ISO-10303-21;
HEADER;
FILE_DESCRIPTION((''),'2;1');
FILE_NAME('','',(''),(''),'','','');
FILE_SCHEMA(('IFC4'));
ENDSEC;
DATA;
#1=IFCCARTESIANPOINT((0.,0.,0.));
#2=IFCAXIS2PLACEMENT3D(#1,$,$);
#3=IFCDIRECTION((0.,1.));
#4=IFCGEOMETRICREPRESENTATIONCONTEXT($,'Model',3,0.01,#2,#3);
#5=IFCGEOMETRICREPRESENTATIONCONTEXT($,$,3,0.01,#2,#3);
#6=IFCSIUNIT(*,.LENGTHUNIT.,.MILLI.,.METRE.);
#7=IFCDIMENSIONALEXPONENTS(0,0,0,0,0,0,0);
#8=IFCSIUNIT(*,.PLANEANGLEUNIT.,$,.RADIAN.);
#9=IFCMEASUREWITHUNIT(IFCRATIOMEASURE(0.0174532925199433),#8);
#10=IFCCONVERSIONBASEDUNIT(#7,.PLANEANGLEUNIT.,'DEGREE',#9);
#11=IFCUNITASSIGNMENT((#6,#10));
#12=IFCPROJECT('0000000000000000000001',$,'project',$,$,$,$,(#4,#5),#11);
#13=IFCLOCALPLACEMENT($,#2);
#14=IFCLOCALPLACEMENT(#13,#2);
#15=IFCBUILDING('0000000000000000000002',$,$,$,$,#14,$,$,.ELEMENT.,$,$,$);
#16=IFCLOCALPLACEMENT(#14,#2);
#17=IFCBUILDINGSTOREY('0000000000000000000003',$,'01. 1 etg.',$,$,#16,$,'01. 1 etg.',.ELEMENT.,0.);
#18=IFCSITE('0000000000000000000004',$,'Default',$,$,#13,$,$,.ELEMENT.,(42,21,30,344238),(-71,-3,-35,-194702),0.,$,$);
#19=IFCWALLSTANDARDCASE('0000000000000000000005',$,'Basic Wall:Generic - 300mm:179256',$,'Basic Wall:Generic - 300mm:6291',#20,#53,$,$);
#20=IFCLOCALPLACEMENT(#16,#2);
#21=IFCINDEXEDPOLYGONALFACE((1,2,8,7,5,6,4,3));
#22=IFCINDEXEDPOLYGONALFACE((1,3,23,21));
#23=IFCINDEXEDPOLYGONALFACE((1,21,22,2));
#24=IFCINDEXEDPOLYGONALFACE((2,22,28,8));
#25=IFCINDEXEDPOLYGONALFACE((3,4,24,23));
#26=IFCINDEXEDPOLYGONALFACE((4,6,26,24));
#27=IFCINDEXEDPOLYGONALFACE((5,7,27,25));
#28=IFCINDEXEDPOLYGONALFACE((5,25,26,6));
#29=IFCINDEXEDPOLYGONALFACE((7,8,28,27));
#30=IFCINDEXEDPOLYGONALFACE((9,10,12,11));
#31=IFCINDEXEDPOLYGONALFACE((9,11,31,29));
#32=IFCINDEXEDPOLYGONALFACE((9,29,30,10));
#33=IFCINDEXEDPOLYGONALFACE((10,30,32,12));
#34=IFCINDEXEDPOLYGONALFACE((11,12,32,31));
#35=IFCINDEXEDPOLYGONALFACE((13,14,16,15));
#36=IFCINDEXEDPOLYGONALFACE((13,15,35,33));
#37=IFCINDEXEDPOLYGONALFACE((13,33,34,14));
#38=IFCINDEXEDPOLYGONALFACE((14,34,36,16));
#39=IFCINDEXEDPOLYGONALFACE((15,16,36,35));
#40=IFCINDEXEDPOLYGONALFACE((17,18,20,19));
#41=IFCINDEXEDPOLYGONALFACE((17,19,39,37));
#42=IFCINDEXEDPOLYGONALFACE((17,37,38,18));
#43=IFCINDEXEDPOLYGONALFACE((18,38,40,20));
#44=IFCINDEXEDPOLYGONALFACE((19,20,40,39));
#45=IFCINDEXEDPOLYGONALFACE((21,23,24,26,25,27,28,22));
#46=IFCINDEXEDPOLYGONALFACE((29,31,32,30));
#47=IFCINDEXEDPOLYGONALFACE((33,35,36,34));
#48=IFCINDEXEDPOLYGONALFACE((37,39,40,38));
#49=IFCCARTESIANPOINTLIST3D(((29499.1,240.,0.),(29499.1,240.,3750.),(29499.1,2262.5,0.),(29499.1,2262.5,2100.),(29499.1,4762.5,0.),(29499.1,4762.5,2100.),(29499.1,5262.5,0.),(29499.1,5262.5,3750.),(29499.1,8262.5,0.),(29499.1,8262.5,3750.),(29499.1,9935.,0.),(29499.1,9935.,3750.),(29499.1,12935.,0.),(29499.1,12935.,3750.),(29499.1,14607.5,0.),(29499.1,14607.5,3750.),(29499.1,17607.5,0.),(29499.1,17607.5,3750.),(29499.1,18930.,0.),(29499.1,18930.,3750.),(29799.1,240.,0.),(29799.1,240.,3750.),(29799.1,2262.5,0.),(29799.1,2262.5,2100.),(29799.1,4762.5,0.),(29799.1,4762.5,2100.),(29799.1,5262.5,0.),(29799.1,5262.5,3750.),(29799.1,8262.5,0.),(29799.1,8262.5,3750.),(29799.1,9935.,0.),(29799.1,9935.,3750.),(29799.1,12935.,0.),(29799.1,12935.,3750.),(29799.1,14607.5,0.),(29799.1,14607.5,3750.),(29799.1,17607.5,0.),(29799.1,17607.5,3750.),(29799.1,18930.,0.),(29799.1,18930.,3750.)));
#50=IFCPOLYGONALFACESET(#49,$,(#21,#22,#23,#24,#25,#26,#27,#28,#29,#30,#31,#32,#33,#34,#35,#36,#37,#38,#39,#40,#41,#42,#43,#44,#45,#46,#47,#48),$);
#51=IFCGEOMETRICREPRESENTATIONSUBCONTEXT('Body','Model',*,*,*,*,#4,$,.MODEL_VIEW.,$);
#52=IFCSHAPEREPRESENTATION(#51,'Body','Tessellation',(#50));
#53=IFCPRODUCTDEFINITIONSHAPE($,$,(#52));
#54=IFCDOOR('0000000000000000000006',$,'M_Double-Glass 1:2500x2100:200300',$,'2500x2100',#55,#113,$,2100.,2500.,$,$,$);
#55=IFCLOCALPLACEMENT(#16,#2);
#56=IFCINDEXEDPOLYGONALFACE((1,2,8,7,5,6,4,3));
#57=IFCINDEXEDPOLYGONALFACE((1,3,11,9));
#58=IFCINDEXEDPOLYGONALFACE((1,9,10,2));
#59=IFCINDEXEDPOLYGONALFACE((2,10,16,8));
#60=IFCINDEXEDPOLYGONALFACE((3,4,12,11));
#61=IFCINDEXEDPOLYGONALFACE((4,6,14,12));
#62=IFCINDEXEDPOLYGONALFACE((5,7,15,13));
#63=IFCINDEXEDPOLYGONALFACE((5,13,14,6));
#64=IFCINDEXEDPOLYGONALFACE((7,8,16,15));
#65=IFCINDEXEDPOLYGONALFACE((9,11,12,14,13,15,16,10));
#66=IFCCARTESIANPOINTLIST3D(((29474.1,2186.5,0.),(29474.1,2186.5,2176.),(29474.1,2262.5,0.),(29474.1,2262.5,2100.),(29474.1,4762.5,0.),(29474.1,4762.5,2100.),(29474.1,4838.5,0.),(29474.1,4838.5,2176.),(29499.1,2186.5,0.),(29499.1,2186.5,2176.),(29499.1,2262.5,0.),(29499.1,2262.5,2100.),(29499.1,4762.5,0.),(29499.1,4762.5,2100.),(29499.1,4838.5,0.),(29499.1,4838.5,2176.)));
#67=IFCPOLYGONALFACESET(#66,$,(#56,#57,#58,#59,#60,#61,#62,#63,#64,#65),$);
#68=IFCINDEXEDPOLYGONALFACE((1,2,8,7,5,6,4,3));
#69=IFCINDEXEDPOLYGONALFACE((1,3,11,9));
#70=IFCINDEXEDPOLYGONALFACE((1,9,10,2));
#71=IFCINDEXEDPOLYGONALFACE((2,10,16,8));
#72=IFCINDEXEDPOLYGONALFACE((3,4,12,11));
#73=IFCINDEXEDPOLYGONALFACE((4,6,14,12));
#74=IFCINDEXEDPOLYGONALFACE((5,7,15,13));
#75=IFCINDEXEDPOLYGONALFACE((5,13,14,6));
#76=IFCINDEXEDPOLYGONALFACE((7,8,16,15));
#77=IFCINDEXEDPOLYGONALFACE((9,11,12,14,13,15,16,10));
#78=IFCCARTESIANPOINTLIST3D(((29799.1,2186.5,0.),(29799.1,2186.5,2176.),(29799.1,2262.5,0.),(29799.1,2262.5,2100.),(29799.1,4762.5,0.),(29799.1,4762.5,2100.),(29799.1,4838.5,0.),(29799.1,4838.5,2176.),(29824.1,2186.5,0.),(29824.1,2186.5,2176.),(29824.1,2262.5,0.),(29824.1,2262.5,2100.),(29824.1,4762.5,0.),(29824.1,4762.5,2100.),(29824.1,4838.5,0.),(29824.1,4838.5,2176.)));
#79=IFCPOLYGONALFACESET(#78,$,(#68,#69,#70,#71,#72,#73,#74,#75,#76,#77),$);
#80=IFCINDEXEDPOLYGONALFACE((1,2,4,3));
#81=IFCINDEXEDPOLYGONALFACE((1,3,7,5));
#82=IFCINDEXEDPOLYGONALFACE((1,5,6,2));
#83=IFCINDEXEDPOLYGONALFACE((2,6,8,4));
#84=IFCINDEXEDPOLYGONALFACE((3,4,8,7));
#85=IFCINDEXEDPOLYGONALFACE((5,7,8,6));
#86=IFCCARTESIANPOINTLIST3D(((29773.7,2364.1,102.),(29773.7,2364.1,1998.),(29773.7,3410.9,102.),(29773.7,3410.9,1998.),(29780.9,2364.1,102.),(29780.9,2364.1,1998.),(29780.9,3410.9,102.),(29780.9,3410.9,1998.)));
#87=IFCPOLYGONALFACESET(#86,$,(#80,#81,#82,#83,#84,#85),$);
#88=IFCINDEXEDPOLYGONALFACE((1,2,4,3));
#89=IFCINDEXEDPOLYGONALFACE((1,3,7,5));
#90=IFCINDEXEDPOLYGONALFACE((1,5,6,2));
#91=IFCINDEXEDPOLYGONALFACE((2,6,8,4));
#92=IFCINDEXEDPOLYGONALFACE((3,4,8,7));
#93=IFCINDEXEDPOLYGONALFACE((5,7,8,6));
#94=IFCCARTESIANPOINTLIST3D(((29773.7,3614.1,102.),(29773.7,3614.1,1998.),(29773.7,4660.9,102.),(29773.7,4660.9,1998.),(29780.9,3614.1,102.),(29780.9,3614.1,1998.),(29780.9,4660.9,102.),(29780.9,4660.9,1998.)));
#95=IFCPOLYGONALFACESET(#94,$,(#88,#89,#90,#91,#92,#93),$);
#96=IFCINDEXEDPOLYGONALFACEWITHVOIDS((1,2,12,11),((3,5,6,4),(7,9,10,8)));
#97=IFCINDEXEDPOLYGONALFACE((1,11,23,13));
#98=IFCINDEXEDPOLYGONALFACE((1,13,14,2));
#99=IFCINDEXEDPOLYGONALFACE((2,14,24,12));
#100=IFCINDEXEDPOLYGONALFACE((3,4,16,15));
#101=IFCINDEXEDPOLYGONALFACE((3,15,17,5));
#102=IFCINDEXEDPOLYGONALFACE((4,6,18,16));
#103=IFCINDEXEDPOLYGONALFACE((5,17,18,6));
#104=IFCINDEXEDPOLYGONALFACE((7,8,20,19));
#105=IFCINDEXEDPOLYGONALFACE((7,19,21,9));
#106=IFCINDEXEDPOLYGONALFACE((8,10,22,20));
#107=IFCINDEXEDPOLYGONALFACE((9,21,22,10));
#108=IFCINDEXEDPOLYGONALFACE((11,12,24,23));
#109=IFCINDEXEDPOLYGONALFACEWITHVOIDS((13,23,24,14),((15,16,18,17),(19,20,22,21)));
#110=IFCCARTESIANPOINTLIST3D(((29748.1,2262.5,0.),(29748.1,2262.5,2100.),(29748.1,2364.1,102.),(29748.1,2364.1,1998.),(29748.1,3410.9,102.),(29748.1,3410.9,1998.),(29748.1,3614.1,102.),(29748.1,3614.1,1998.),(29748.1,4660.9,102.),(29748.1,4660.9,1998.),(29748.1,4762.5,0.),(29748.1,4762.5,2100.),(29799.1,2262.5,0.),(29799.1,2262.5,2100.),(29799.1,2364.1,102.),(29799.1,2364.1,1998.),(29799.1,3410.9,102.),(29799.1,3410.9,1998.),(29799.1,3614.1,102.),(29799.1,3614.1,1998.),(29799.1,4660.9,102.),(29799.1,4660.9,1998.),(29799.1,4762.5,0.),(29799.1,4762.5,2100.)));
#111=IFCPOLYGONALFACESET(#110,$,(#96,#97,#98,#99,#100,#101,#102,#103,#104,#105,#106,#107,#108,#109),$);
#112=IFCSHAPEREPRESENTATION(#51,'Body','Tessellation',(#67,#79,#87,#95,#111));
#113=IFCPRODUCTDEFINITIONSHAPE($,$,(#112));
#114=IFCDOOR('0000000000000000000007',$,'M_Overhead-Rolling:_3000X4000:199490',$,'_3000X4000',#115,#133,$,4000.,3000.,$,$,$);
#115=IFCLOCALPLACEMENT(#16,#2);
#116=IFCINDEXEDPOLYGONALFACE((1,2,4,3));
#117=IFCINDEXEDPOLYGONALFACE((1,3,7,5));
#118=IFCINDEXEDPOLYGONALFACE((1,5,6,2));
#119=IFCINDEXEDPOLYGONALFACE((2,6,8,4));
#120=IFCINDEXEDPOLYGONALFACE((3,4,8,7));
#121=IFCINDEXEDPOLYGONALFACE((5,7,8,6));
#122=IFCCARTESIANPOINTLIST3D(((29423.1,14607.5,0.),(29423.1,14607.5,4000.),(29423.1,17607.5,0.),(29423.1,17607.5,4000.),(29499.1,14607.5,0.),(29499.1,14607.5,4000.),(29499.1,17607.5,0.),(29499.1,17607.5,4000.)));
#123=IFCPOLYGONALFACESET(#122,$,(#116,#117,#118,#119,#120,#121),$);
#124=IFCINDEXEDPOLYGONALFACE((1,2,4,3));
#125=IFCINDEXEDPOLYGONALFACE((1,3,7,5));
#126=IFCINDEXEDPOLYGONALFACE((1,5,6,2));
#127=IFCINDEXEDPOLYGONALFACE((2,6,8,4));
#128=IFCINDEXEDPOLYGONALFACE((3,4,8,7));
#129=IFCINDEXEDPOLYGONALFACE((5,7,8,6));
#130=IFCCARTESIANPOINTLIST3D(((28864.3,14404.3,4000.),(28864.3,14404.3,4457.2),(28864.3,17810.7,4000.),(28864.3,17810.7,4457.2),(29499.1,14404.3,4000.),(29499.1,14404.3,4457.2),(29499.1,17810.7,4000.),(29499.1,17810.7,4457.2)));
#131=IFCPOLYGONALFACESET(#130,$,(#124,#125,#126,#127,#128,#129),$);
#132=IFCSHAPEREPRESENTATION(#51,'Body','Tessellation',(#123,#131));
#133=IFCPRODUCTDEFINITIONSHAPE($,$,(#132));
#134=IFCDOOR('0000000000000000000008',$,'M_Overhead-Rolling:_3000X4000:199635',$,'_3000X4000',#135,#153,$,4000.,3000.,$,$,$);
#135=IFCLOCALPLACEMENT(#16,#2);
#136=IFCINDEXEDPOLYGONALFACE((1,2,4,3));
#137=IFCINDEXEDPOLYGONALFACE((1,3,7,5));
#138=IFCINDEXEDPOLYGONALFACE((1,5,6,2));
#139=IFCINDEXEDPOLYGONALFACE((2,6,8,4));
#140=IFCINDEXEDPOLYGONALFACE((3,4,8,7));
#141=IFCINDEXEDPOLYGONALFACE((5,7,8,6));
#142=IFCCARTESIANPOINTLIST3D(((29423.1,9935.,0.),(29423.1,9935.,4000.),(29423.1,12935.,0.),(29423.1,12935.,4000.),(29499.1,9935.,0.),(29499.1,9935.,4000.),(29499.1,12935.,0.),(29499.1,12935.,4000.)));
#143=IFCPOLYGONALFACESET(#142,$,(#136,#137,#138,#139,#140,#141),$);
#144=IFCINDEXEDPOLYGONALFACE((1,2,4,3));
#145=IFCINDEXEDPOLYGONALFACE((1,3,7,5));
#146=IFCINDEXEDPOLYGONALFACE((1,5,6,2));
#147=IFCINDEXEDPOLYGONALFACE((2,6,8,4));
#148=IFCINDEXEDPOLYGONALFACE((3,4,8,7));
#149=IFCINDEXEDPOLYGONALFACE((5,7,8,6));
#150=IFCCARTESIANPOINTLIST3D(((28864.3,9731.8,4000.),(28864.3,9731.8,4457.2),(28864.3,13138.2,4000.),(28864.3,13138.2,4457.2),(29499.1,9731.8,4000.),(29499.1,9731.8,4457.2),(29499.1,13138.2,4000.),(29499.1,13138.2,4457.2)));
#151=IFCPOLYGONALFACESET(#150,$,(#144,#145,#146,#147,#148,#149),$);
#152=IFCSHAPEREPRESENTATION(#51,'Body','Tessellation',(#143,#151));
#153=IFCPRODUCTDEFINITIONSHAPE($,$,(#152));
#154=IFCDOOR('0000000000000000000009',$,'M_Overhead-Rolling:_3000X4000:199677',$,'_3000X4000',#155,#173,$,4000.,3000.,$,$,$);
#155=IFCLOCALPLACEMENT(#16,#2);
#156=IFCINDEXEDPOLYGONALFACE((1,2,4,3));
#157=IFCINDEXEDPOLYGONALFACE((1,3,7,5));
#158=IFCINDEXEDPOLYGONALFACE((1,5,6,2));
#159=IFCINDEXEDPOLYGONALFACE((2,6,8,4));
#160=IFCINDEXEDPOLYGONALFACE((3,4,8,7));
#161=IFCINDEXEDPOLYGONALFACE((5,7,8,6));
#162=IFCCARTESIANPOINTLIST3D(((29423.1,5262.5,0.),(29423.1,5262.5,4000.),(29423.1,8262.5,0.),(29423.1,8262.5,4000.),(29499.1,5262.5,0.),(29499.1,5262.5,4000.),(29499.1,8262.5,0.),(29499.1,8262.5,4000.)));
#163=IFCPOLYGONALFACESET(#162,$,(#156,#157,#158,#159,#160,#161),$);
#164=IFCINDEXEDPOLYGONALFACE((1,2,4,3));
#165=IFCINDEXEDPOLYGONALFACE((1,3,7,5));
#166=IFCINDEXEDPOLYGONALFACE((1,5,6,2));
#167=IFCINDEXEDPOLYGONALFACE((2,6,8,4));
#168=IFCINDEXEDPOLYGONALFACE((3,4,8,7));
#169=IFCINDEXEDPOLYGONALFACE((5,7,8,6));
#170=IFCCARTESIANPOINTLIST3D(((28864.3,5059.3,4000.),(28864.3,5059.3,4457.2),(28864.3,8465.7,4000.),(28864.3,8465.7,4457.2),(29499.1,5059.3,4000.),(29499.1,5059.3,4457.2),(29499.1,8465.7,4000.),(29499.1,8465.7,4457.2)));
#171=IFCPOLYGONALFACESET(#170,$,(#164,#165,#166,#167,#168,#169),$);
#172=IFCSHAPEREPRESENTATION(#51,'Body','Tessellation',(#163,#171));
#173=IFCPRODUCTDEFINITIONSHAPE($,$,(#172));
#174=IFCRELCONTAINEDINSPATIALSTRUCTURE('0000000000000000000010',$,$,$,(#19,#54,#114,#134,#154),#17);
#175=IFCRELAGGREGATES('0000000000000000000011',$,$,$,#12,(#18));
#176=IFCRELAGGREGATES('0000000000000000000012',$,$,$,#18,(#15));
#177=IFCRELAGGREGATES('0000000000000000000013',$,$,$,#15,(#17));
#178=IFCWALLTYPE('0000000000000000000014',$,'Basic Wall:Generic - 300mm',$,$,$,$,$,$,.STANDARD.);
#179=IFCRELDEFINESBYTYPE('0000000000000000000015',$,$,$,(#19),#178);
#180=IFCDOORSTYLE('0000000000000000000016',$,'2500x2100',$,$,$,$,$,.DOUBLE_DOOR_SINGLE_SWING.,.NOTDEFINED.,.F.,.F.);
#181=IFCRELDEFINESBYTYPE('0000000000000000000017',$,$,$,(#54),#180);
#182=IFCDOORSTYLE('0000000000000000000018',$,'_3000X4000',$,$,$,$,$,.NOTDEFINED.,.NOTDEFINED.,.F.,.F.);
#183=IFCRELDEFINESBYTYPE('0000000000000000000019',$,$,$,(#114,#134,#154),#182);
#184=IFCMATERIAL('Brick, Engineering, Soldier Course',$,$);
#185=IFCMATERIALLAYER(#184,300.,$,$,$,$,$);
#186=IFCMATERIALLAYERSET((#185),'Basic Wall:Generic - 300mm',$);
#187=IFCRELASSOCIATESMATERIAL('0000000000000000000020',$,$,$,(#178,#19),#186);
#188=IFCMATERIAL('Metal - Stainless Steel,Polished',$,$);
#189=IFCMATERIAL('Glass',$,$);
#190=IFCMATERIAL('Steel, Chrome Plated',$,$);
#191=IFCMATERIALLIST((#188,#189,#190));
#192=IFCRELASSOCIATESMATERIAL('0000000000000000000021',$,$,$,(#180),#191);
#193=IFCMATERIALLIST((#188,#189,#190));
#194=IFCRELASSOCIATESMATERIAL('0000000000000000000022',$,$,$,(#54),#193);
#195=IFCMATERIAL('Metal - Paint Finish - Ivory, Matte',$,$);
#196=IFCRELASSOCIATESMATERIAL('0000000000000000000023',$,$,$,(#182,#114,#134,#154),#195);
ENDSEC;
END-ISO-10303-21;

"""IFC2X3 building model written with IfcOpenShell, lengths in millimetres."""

from ifc_helpers import new_model, entity, si_unit, converted_unit, direction, frame, frame_2d, origin, origin_2d_with_axis, place, context, subcontext, project, spatial, polyline, rectangle, outline, extrude, clip, halfspace, source, transform, mapped, material, material_list, layer, layer_set, layer_usage, type_object, type_shapes, element, fill, save


model = new_model("IFC2X3")

# Units and contexts
model_context = context("Model", 3, precision=0.01, world=origin(), true_north=direction((0.0, 1.0)))
context_of_model = context(None, 3, precision=0.01, world=origin(), true_north=direction((0.0, 1.0)))
body_context = subcontext(model_context, "Body", "Model", "MODEL_VIEW")
ifc_project = project(units=[si_unit("LENGTHUNIT", "METRE", prefix="MILLI"), converted_unit("PLANEANGLEUNIT", "DEGREE", entity("IfcRatioMeasure", 0.0174532925199433), si_unit("PLANEANGLEUNIT", "RADIAN"), dimensions=[0, 0, 0, 0, 0, 0, 0])], contexts=[model_context, context_of_model])

# Site, building, storey
site_placement = place(None, origin())
site = spatial("IfcSite", under=ifc_project, at=site_placement, Name="Default", CompositionType="ELEMENT", RefLatitude=(42, 21, 30, 344238), RefLongitude=(-71, -3, -35, -194702), RefElevation=0.0)
building_placement = place(site_placement, origin())
building = spatial("IfcBuilding", under=site, at=building_placement, CompositionType="ELEMENT")
storey_placement = place(building_placement, origin())
storey = spatial("IfcBuildingStorey", under=building, at=storey_placement, Name="01. 1 etg.", LongName="01. 1 etg.", CompositionType="ELEMENT", Elevation=0.0)

# Shared definitions
ifc_material_1 = material(Name="Brick, Engineering, Soldier Course")
ifc_layer_1 = layer(ifc_material_1, 300.0)
ifc_layer_set_1 = layer_set([ifc_layer_1], Name="Basic Wall:Generic - 300mm")
wall_type_1 = type_object("IfcWallType", Name="Basic Wall:Generic - 300mm", PredefinedType="STANDARD", material=ifc_layer_set_1)
ifc_material_2 = material(Name="Glass")

# Wall, openings, doors
ifc_layer_usage_1 = layer_usage(ifc_layer_set_1, "AXIS2", "NEGATIVE", 150.0)
wall_1_placement = place(storey_placement, frame((29649.1, 18930.0, 0.0), z_axis=(0.0, 0.0, 1.0), x_axis=(0.0, -1.0, 0.0)))
wall_1 = element("IfcWallStandardCase", 1, at=wall_1_placement, inside=storey, type_object=wall_type_1, material=ifc_layer_usage_1, Name="Basic Wall:Generic - 300mm:179256", ObjectType="Basic Wall:Generic - 300mm:6291", context=body_context, shape_type="Clipping", body=[
    clip(extrude(rectangle(XDim=18690.0, YDim=300.0, at=frame_2d((9345.0, 0.0), x_axis=(-1.0, 0.0))), origin(), (0.0, 0.0, 1.0), 3750.0), halfspace(origin(), True)),
])
opening_1_placement = place(wall_1_placement, frame((4322.5, 150.0, 0.0)))
opening_1 = element("IfcOpeningElement", 2, at=opening_1_placement, cuts=wall_1, ObjectType="Opening", context=body_context, shape_type="SweptSolid", body=[
    extrude(rectangle(XDim=4000.0, YDim=3000.0, at=frame_2d((2000.0, 1500.0), x_axis=(1.0, 0.0))), frame((0.0, 0.0, 0.0), z_axis=(0.0, -1.0, 0.0), x_axis=(0.0, 0.0, 1.0)), (0.0, 0.0, 1.0), 300.0),
])
opening_2_placement = place(wall_1_placement, frame((8995.0, 150.0, 0.0)))
opening_2 = element("IfcOpeningElement", 3, at=opening_2_placement, cuts=wall_1, ObjectType="Opening", context=body_context, shape_type="SweptSolid", body=[
    extrude(rectangle(XDim=4000.0, YDim=3000.0, at=frame_2d((2000.0, 1500.0), x_axis=(1.0, 0.0))), frame((0.0, 0.0, 0.0), z_axis=(0.0, -1.0, 0.0), x_axis=(0.0, 0.0, 1.0)), (0.0, 0.0, 1.0), 300.0),
])
opening_3_placement = place(wall_1_placement, frame((13667.5, 150.0, 0.0)))
opening_3 = element("IfcOpeningElement", 4, at=opening_3_placement, cuts=wall_1, ObjectType="Opening", context=body_context, shape_type="SweptSolid", body=[
    extrude(rectangle(XDim=4000.0, YDim=3000.0, at=frame_2d((2000.0, 1500.0), x_axis=(1.0, 0.0))), frame((0.0, 0.0, 0.0), z_axis=(0.0, -1.0, 0.0), x_axis=(0.0, 0.0, 1.0)), (0.0, 0.0, 1.0), 300.0),
])
opening_4_placement = place(wall_1_placement, frame((14167.5, -150.0, 0.0)))
opening_4 = element("IfcOpeningElement", 5, at=opening_4_placement, cuts=wall_1, ObjectType="Opening", context=body_context, shape_type="SweptSolid", body=[
    extrude(rectangle(XDim=2500.0, YDim=2100.0, at=frame_2d((1050.0, 1250.0), x_axis=(0.0, 1.0))), frame((0.0, 0.0, 0.0), z_axis=(0.0, 1.0, 0.0), x_axis=(0.0, 0.0, 1.0)), (0.0, 0.0, 1.0), 300.0),
])
ifc_material_3 = material(Name="Metal - Stainless Steel,Polished")
ifc_material_4 = material(Name="Steel, Chrome Plated")
ifc_material_list_1 = material_list([ifc_material_3, ifc_material_2, ifc_material_4])
ifc_material_list_2 = material_list([ifc_material_3, ifc_material_2, ifc_material_4])
door_style_1 = type_object("IfcDoorStyle", Name="2500x2100", ConstructionType="NOTDEFINED", OperationType="DOUBLE_DOOR_SINGLE_SWING", ParameterTakesPrecedence=False, Sizeable=False, material=ifc_material_list_2)
shared_shape_1 = source(origin(), body_context, "Body", "SweptSolid", [
    extrude(outline(polyline([(-1326.0, -1069.0), (-1250.0, -1069.0), (-1250.0, 1031.0), (1250.0, 1031.0), (1250.0, -1069.0), (1326.0, -1069.0), (1326.0, 1107.0), (-1326.0, 1107.0), (-1326.0, -1069.0)])), frame((1250.0, -25.0, 1069.0), z_axis=(0.0, 1.0, 0.0), x_axis=(-1.0, 0.0, 0.0)), (0.0, 0.0, 1.0), 25.0),
    extrude(outline(polyline([(-1250.0, -1031.0), (-1250.0, 1069.0), (-1326.0, 1069.0), (-1326.0, -1107.0), (1326.0, -1107.0), (1326.0, 1069.0), (1250.0, 1069.0), (1250.0, -1031.0), (-1250.0, -1031.0)])), frame((1250.0, 300.0, 1069.0), z_axis=(0.0, -1.0, 0.0), x_axis=(-1.0, 0.0, 0.0)), (0.0, 0.0, -1.0), 25.0),
    extrude(rectangle(XDim=7.1, YDim=1046.8, at=frame_2d((0.0, 0.0), x_axis=(1.0, 0.0))), frame((1875.0, 278.2, 102.0), z_axis=(0.0, 0.0, 1.0), x_axis=(0.0, 1.0, 0.0)), (0.0, 0.0, 1.0), 1896.0),
    extrude(rectangle(XDim=7.1, YDim=1046.8, at=frame_2d((0.0, 0.0), x_axis=(1.0, 0.0))), frame((625.0, 278.2, 102.0), z_axis=(0.0, 0.0, 1.0), x_axis=(0.0, 1.0, 0.0)), (0.0, 0.0, 1.0), 1896.0),
    extrude(outline(polyline([(-1050.0, -1250.0), (1050.0, -1250.0), (1050.0, 1250.0), (-1050.0, 1250.0), (-1050.0, -1250.0)]), holes=[polyline([(-948.0, 101.6), (-948.0, 1148.4), (948.0, 1148.4), (948.0, 101.6), (-948.0, 101.6)]), polyline([(-948.0, -1148.4), (-948.0, -101.6), (948.0, -101.6), (948.0, -1148.4), (-948.0, -1148.4)])]), frame((1250.0, 249.0, 1050.0), z_axis=(0.0, 1.0, 0.0), x_axis=(0.0, 0.0, -1.0)), (0.0, 0.0, 1.0), 51.0),
])
type_shapes(door_style_1, [shared_shape_1])
door_1_placement = place(opening_4_placement, origin())
door_1 = element("IfcDoor", 6, at=door_1_placement, inside=storey, type_object=door_style_1, material=ifc_material_list_1, Name="M_Double-Glass 1:2500x2100:200300", ObjectType="2500x2100", OverallHeight=2100.0, OverallWidth=2500.0, context=body_context, shape_type="MappedRepresentation", body=[
    mapped(shared_shape_1, transform((0.0, 0.0, 0.0), scale=1.0)),
])
fill(opening_4, door_1)
ifc_material_5 = material(Name="Metal - Paint Finish - Ivory, Matte")
door_style_2 = type_object("IfcDoorStyle", Name="_3000X4000", ConstructionType="NOTDEFINED", OperationType="NOTDEFINED", ParameterTakesPrecedence=False, Sizeable=False, material=ifc_material_5)
shared_shape_2 = source(origin(), body_context, "Body", "SweptSolid", [
    extrude(rectangle(XDim=3000.0, YDim=76.0, at=frame_2d((0.0, 0.0), x_axis=(1.0, 0.0))), frame((1500.0, -38.0, 0.0), z_axis=(0.0, 0.0, 1.0), x_axis=(-1.0, 0.0, 0.0)), (0.0, 0.0, 1.0), 4000.0),
    extrude(rectangle(XDim=634.8, YDim=3406.4, at=origin_2d_with_axis()), frame((1500.0, -317.4, 4000.0), z_axis=(0.0, 0.0, 1.0), x_axis=(0.0, 1.0, 0.0)), (0.0, 0.0, 1.0), 457.2),
])
type_shapes(door_style_2, [shared_shape_2])
door_2_placement = place(opening_1_placement, frame((-3000.0, -300.0, 0.0)))
door_2 = element("IfcDoor", 7, at=door_2_placement, inside=storey, type_object=door_style_2, material=ifc_material_5, Name="M_Overhead-Rolling:_3000X4000:199490", ObjectType="_3000X4000", OverallHeight=4000.0, OverallWidth=3000.0, context=body_context, shape_type="MappedRepresentation", body=[
    mapped(shared_shape_2, transform((0.0, 0.0, 0.0), scale=1.0)),
])
fill(opening_1, door_2)
door_3_placement = place(opening_2_placement, frame((-3000.0, -300.0, 0.0)))
door_3 = element("IfcDoor", 8, at=door_3_placement, inside=storey, type_object=door_style_2, material=ifc_material_5, Name="M_Overhead-Rolling:_3000X4000:199635", ObjectType="_3000X4000", OverallHeight=4000.0, OverallWidth=3000.0, context=body_context, shape_type="MappedRepresentation", body=[
    mapped(shared_shape_2, transform((0.0, 0.0, 0.0), scale=1.0)),
])
fill(opening_2, door_3)
door_4_placement = place(opening_3_placement, frame((-3000.0, -300.0, 0.0)))
door_4 = element("IfcDoor", 9, at=door_4_placement, inside=storey, type_object=door_style_2, material=ifc_material_5, Name="M_Overhead-Rolling:_3000X4000:199677", ObjectType="_3000X4000", OverallHeight=4000.0, OverallWidth=3000.0, context=body_context, shape_type="MappedRepresentation", body=[
    mapped(shared_shape_2, transform((0.0, 0.0, 0.0), scale=1.0)),
])
fill(opening_3, door_4)

save(model, "model.ifc")
